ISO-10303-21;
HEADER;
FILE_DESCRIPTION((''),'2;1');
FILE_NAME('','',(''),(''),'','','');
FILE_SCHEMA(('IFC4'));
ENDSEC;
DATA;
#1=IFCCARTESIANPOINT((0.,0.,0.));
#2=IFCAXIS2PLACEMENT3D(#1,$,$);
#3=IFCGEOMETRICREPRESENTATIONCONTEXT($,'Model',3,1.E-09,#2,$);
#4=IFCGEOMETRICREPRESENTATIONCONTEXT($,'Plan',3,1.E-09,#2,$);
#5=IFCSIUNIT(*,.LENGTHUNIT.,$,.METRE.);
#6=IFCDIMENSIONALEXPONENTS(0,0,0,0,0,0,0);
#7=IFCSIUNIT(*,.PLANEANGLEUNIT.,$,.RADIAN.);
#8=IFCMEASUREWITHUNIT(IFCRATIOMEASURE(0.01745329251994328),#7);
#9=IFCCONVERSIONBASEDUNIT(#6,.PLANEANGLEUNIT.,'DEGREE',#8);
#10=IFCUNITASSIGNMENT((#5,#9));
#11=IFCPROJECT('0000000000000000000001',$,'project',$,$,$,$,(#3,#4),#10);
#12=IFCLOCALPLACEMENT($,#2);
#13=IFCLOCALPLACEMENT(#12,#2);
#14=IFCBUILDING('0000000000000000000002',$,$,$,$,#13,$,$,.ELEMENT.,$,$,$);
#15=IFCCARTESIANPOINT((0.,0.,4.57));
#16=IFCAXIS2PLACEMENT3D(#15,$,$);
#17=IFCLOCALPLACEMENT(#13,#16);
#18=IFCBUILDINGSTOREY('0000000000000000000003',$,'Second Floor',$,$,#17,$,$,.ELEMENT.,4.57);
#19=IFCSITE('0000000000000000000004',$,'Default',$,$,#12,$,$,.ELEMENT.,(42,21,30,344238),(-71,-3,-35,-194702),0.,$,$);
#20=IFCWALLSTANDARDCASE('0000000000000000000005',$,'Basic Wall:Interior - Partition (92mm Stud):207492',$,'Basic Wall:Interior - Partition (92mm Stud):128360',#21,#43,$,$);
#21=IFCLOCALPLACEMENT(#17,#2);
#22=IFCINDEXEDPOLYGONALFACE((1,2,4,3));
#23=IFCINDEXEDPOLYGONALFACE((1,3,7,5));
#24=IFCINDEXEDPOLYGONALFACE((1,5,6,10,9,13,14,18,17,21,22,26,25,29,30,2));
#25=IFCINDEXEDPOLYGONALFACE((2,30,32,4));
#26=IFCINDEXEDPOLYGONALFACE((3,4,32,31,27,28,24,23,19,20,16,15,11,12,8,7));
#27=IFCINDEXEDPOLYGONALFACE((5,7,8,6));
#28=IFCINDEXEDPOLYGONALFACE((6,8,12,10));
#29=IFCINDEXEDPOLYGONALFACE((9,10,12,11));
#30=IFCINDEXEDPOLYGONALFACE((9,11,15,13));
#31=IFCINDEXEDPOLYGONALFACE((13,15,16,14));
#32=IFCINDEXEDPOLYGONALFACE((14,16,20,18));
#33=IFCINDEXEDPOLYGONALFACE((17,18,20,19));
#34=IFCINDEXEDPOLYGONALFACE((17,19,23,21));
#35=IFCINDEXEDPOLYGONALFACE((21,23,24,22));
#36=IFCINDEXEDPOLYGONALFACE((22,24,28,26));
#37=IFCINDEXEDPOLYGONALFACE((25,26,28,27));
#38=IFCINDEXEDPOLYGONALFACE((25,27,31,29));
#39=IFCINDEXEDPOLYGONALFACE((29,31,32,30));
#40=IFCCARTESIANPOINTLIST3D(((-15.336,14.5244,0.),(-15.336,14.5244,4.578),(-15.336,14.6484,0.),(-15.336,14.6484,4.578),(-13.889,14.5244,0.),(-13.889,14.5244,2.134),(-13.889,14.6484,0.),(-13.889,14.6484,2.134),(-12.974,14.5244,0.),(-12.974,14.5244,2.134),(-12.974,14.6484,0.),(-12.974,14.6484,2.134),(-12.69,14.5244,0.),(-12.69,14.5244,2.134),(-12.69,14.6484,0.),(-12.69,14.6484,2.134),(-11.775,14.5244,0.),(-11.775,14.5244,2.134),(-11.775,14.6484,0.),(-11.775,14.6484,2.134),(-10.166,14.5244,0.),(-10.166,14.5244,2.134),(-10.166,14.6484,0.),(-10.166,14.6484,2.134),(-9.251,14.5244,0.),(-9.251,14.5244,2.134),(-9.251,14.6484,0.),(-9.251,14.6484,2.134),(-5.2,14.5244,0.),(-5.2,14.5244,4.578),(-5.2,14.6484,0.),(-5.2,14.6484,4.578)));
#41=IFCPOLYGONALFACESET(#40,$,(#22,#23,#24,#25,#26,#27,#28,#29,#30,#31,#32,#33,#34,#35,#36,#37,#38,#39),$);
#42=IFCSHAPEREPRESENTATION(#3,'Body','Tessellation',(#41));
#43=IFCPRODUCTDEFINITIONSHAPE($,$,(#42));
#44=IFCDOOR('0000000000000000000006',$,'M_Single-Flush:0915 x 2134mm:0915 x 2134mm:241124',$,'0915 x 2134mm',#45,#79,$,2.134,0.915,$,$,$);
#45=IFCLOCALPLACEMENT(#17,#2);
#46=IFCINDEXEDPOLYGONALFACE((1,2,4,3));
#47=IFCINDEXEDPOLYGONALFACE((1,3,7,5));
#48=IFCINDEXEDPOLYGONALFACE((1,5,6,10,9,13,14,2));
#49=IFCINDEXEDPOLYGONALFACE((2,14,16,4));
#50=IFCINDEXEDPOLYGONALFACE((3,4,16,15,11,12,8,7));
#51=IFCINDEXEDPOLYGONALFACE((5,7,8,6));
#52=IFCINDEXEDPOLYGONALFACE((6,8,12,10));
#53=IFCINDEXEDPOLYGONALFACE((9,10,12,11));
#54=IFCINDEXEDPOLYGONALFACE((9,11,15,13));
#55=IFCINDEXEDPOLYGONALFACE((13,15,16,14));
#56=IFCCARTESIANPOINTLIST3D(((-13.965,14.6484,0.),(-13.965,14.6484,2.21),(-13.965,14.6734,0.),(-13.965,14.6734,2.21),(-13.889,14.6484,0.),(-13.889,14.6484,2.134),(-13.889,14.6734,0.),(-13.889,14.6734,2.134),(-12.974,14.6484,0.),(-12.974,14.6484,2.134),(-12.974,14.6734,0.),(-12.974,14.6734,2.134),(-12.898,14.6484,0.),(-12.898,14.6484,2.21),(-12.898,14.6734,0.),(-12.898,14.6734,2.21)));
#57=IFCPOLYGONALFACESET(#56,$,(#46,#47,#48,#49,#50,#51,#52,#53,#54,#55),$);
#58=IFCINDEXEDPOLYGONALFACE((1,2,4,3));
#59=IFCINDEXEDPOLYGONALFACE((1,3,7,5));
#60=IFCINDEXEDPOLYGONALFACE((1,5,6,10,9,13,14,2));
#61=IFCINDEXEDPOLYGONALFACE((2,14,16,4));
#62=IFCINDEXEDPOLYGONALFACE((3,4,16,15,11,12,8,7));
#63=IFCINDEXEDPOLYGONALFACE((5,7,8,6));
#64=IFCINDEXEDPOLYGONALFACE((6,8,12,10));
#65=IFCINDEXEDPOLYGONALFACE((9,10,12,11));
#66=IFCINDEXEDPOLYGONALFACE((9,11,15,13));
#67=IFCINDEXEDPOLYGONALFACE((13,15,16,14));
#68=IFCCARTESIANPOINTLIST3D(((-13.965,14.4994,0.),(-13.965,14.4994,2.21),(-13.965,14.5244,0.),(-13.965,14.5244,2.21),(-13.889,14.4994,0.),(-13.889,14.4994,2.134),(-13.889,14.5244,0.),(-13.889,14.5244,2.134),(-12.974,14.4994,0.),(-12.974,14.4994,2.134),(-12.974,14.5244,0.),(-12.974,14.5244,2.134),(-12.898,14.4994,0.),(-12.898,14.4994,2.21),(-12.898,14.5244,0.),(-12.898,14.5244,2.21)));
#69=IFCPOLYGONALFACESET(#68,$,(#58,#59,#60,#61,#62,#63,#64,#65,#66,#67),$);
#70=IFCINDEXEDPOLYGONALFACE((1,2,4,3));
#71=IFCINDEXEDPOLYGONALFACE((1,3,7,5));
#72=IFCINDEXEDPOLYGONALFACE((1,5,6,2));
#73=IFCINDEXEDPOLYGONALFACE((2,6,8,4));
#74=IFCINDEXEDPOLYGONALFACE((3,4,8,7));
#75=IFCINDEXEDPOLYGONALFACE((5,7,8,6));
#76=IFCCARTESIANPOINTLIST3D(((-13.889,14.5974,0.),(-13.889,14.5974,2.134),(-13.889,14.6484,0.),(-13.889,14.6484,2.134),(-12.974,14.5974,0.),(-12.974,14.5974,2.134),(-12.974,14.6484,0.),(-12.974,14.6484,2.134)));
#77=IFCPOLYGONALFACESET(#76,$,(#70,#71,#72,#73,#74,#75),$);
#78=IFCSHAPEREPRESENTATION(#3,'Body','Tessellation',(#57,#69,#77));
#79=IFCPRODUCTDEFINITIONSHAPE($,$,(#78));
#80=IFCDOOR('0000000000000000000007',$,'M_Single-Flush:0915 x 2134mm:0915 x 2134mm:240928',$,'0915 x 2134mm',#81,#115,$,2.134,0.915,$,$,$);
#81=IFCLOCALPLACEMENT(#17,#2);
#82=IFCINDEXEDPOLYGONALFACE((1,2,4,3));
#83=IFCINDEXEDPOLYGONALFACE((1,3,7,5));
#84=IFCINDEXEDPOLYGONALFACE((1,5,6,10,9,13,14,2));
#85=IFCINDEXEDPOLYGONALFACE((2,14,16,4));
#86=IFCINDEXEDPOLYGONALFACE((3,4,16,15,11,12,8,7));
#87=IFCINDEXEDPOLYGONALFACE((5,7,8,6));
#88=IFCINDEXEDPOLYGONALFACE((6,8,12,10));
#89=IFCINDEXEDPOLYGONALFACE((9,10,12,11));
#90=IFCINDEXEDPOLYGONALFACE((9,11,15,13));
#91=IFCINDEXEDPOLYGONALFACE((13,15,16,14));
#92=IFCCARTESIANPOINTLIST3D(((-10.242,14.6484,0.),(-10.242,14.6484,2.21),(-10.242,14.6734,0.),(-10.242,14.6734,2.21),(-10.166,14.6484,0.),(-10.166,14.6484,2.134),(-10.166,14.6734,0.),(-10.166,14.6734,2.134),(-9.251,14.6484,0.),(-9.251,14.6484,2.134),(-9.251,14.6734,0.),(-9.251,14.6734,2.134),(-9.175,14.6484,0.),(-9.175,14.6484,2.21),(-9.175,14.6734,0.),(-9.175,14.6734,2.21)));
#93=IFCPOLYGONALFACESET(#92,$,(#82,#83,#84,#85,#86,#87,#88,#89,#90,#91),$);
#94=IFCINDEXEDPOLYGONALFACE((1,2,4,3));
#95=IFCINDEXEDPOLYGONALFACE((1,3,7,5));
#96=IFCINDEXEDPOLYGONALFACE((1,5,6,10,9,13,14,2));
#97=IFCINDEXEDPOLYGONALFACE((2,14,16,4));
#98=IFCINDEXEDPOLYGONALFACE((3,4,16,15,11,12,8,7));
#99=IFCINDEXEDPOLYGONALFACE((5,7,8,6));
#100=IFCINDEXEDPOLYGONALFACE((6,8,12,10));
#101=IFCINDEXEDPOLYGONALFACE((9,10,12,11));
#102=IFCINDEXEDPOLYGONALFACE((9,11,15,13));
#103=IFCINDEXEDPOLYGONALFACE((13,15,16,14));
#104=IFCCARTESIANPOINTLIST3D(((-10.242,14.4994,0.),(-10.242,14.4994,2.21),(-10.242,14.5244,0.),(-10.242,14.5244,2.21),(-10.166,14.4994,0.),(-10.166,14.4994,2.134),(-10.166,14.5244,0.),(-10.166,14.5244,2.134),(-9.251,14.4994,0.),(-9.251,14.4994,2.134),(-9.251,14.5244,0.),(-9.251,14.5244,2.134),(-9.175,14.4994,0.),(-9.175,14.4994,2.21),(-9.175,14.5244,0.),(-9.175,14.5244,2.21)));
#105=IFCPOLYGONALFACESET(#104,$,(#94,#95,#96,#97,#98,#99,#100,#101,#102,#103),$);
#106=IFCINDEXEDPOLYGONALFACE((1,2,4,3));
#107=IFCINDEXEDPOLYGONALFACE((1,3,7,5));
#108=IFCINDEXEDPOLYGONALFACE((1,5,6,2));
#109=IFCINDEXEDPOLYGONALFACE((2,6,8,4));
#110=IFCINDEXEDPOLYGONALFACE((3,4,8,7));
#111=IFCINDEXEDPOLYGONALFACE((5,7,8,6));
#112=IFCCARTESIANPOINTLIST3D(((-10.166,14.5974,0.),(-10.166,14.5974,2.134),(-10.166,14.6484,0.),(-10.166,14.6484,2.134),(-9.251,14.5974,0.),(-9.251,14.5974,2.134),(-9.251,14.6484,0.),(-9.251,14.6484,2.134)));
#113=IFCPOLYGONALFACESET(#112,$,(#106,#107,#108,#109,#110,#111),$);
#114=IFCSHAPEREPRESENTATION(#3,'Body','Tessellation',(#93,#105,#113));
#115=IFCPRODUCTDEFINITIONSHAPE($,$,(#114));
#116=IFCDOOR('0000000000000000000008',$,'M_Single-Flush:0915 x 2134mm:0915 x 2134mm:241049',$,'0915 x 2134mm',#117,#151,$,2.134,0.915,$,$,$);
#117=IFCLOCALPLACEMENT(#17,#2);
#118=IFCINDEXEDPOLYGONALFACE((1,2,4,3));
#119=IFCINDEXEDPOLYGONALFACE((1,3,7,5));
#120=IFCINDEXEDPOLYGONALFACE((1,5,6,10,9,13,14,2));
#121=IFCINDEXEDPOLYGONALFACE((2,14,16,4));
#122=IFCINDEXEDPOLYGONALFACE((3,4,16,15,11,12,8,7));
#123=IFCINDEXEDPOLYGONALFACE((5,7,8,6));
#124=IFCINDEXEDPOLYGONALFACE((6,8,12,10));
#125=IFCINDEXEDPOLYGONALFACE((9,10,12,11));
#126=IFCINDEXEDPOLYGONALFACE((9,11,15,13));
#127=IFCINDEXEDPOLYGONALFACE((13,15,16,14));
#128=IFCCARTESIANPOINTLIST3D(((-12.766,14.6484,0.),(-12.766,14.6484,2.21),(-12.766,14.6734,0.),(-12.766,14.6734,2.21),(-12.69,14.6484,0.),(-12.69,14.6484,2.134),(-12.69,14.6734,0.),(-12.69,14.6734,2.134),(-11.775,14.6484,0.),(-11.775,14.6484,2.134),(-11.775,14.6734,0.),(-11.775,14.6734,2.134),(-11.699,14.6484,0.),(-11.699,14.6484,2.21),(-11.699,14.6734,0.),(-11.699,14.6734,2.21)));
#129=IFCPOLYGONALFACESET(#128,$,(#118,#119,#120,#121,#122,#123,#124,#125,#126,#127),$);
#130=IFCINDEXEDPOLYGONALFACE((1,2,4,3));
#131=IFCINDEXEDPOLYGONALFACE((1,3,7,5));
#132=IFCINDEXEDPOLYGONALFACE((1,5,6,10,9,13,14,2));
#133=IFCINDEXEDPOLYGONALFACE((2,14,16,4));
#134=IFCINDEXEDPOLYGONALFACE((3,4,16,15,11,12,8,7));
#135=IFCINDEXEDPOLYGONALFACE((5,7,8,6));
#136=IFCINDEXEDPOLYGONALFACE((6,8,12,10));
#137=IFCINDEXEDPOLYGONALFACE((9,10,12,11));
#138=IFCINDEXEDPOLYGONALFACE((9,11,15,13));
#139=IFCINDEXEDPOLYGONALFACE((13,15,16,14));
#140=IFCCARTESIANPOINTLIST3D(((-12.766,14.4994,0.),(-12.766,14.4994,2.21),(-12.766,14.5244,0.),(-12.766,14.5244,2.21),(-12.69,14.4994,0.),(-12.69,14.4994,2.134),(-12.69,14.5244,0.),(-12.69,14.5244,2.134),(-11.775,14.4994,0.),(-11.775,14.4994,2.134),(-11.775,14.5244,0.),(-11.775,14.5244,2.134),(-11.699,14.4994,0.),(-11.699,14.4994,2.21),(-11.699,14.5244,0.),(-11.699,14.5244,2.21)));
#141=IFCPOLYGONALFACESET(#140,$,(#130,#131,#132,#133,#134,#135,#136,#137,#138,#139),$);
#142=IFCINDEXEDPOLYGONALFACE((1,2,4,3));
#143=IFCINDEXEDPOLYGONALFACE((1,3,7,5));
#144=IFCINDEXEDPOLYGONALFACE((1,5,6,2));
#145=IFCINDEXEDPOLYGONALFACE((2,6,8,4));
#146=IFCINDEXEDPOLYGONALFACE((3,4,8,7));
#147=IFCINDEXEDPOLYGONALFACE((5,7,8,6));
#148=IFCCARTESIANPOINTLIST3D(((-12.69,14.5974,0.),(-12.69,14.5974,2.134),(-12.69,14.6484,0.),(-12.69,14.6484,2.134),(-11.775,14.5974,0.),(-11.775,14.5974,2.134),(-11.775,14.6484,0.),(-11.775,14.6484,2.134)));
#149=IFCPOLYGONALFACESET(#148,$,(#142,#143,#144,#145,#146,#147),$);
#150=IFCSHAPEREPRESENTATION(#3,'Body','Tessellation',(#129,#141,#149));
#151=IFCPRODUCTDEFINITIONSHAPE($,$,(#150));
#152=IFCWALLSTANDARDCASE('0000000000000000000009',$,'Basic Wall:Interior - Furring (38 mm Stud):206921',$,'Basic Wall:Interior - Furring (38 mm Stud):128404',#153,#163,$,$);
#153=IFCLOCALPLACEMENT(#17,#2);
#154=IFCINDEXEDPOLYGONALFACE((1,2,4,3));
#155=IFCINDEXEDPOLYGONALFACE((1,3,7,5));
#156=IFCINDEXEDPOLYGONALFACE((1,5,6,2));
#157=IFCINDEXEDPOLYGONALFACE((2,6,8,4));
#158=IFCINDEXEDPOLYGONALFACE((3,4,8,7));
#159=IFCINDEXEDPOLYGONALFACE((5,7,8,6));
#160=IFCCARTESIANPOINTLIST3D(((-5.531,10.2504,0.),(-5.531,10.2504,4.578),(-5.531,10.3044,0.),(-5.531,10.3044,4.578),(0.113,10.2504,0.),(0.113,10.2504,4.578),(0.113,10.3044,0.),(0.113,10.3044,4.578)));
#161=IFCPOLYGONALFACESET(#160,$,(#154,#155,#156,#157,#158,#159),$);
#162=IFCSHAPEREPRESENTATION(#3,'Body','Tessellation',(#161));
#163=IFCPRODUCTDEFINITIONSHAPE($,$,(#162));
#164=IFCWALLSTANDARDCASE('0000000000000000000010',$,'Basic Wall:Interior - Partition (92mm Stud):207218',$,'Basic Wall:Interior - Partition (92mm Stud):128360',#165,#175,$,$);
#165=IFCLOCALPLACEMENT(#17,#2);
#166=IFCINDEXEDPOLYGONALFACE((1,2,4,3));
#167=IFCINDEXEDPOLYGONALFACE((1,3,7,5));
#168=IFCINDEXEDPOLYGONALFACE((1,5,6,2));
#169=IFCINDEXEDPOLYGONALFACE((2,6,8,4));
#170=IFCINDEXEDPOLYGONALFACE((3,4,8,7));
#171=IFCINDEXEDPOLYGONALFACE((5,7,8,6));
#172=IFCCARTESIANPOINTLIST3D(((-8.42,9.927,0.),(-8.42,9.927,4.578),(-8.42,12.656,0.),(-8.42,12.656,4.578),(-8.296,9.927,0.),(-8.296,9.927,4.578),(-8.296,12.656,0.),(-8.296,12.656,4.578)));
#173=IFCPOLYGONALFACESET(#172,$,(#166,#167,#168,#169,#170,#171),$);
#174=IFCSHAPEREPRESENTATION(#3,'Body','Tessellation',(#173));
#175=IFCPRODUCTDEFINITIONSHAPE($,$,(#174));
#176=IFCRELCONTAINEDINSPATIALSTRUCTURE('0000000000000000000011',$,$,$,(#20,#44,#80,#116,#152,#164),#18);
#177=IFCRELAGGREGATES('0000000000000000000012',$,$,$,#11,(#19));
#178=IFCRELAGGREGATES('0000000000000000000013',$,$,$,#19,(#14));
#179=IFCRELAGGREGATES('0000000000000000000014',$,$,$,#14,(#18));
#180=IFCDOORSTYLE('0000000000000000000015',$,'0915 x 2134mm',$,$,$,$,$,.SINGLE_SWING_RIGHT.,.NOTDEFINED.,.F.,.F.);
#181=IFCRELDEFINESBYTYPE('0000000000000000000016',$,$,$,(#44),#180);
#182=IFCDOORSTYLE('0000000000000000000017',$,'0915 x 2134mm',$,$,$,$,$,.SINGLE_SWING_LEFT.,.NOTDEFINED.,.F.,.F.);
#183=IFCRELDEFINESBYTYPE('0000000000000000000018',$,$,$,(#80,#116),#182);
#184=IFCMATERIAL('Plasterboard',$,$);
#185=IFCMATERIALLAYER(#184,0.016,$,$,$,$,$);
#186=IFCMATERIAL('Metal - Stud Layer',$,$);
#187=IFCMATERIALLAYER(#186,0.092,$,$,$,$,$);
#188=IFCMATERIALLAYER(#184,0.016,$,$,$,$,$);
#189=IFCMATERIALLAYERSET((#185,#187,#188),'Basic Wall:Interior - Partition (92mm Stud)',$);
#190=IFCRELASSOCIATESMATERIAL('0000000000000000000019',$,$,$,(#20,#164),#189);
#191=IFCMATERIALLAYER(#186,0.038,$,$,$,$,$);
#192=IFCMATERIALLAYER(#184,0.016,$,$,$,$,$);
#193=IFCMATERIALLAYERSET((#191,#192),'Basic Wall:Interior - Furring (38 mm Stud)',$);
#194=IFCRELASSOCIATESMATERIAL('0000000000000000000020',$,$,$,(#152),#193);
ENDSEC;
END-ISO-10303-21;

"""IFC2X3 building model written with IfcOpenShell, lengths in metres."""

from ifc_helpers import new_model, entity, si_unit, converted_unit, frame, frame_2d, origin, origin_2d_with_axis, place, context, project, spatial, polyline, rectangle, outline, extrude, source, transform, mapped, material, layer, layer_set, layer_usage, type_object, type_shapes, element, fill, save


model = new_model("IFC2X3")

# Units and contexts
model_context = context("Model", 3, precision=1e-09, world=origin())
plan_context = context("Plan", 3, precision=1e-09, world=origin())
ifc_project = project(units=[si_unit("LENGTHUNIT", "METRE"), converted_unit("PLANEANGLEUNIT", "DEGREE", entity("IfcRatioMeasure", 0.01745329251994328), si_unit("PLANEANGLEUNIT", "RADIAN"), dimensions=[0, 0, 0, 0, 0, 0, 0])], contexts=[model_context, plan_context])

# Site, building, storey
site_placement = place(None, origin())
site = spatial("IfcSite", under=ifc_project, at=site_placement, Name="Default", CompositionType="ELEMENT", RefLatitude=(42, 21, 30, 344238), RefLongitude=(-71, -3, -35, -194702), RefElevation=0.0)
building_placement = place(site_placement, origin())
building = spatial("IfcBuilding", under=site, at=building_placement, CompositionType="ELEMENT")
storey_placement = place(building_placement, frame((0.0, 0.0, 4.57)))
storey = spatial("IfcBuildingStorey", under=building, at=storey_placement, Name="Second Floor", CompositionType="ELEMENT", Elevation=4.57)

# Wall, openings, doors
ifc_material_1 = material(Name="Plasterboard")
ifc_layer_1 = layer(ifc_material_1, 0.016)
ifc_material_2 = material(Name="Metal - Stud Layer")
ifc_layer_2 = layer(ifc_material_2, 0.092)
ifc_layer_3 = layer(ifc_material_1, 0.016)
ifc_layer_set_1 = layer_set([ifc_layer_1, ifc_layer_2, ifc_layer_3], Name="Basic Wall:Interior - Partition (92mm Stud)")
ifc_layer_usage_1 = layer_usage(ifc_layer_set_1, "AXIS2", "NEGATIVE", 0.062)
wall_1_placement = place(storey_placement, frame((-5.2, 14.5864, 0.0), z_axis=(0.0, 0.0, 1.0), x_axis=(-1.0, 0.0, 0.0)))
wall_1 = element("IfcWallStandardCase", 1, at=wall_1_placement, inside=storey, material=ifc_layer_usage_1, Name="Basic Wall:Interior - Partition (92mm Stud):207492", ObjectType="Basic Wall:Interior - Partition (92mm Stud):128360", context=model_context, shape_type="SweptSolid", body=[
    extrude(rectangle(XDim=10.136, YDim=0.124, at=frame_2d((5.068, 0.0), x_axis=(-1.0, 0.0))), origin(), (0.0, 0.0, 1.0), 4.578),
])
opening_1_placement = place(wall_1_placement, frame((4.966, 0.062, 0.0)))
opening_1 = element("IfcOpeningElement", 2, at=opening_1_placement, cuts=wall_1, ObjectType="Opening", context=model_context, shape_type="SweptSolid", body=[
    extrude(rectangle(XDim=0.915, YDim=2.134, at=frame_2d((1.067, 0.4575), x_axis=(0.0, -1.0))), frame((0.0, 0.0, 0.0), z_axis=(0.0, -1.0, 0.0), x_axis=(0.0, 0.0, 1.0)), (0.0, 0.0, 1.0), 0.124),
])
opening_2_placement = place(wall_1_placement, frame((8.689, 0.062, 0.0)))
opening_2 = element("IfcOpeningElement", 3, at=opening_2_placement, cuts=wall_1, ObjectType="Opening", context=model_context, shape_type="SweptSolid", body=[
    extrude(rectangle(XDim=0.915, YDim=2.134, at=frame_2d((1.067, 0.4575), x_axis=(0.0, 1.0))), frame((0.0, 0.0, 0.0), z_axis=(0.0, -1.0, 0.0), x_axis=(0.0, 0.0, 1.0)), (0.0, 0.0, 1.0), 0.124),
])
opening_3_placement = place(wall_1_placement, frame((7.49, 0.062, 0.0)))
opening_3 = element("IfcOpeningElement", 4, at=opening_3_placement, cuts=wall_1, ObjectType="Opening", context=model_context, shape_type="SweptSolid", body=[
    extrude(rectangle(XDim=0.915, YDim=2.134, at=frame_2d((1.067, 0.4575), x_axis=(0.0, -1.0))), frame((0.0, 0.0, 0.0), z_axis=(0.0, -1.0, 0.0), x_axis=(0.0, 0.0, 1.0)), (0.0, 0.0, 1.0), 0.124),
])
door_style_1 = type_object("IfcDoorStyle", Name="0915 x 2134mm", ConstructionType="NOTDEFINED", OperationType="SINGLE_SWING_RIGHT", ParameterTakesPrecedence=False, Sizeable=False)
shared_shape_1 = source(origin(), model_context, "Body", "SweptSolid", [
    extrude(outline(polyline([(-0.5335, -1.124), (0.5335, -1.124), (0.5335, 1.086), (0.4575, 1.086), (0.4575, -1.048), (-0.4575, -1.048), (-0.4575, 1.086), (-0.5335, 1.086), (-0.5335, -1.124)])), frame((0.4575, 0.124, 1.086), z_axis=(0.0, 1.0, 0.0), x_axis=(1.0, 0.0, 0.0)), (0.0, 0.0, 1.0), 0.025),
    extrude(outline(polyline([(-1.124, -0.5335), (1.086, -0.5335), (1.086, -0.4575), (-1.048, -0.4575), (-1.048, 0.4575), (1.086, 0.4575), (1.086, 0.5335), (-1.124, 0.5335), (-1.124, -0.5335)])), frame((0.4575, -0.025, 1.086), z_axis=(0.0, 1.0, 0.0), x_axis=(0.0, 0.0, -1.0)), (0.0, 0.0, 1.0), 0.025),
    extrude(rectangle(XDim=0.051, YDim=0.915, at=origin_2d_with_axis()), frame((0.4575, 0.0985, 0.0), z_axis=(0.0, 0.0, 1.0), x_axis=(0.0, 1.0, 0.0)), (0.0, 0.0, 1.0), 2.134),
])
type_shapes(door_style_1, [shared_shape_1])
door_1_placement = place(opening_2_placement, frame((0.0, 0.0, 0.0), z_axis=(0.0, 0.0, 1.0), x_axis=(-1.0, 0.0, 0.0)))
door_1 = element("IfcDoor", 5, at=door_1_placement, inside=storey, type_object=door_style_1, Name="M_Single-Flush:0915 x 2134mm:0915 x 2134mm:241124", ObjectType="0915 x 2134mm", OverallHeight=2.134, OverallWidth=0.915, context=model_context, shape_type="MappedRepresentation", body=[
    mapped(shared_shape_1, transform((0.0, 0.0, 0.0), scale=1.0)),
])
fill(opening_2, door_1)
door_style_2 = type_object("IfcDoorStyle", Name="0915 x 2134mm", ConstructionType="NOTDEFINED", OperationType="SINGLE_SWING_LEFT", ParameterTakesPrecedence=False, Sizeable=False)
shared_shape_2 = source(origin(), model_context, "Body", "SweptSolid", [
    extrude(outline(polyline([(-0.5335, -1.124), (0.5335, -1.124), (0.5335, 1.086), (0.4575, 1.086), (0.4575, -1.048), (-0.4575, -1.048), (-0.4575, 1.086), (-0.5335, 1.086), (-0.5335, -1.124)])), frame((0.4575, 0.149, 1.086), z_axis=(0.0, -1.0, 0.0), x_axis=(-1.0, 0.0, 0.0)), (0.0, 0.0, 1.0), 0.025),
    extrude(outline(polyline([(-1.124, -0.5335), (1.086, -0.5335), (1.086, -0.4575), (-1.048, -0.4575), (-1.048, 0.4575), (1.086, 0.4575), (1.086, 0.5335), (-1.124, 0.5335), (-1.124, -0.5335)])), frame((0.4575, 0.0, 1.086), z_axis=(0.0, -1.0, 0.0), x_axis=(0.0, 0.0, -1.0)), (0.0, 0.0, 1.0), 0.025),
    extrude(rectangle(XDim=0.915, YDim=0.051, at=origin_2d_with_axis()), frame((0.4575, 0.0985, 0.0)), (0.0, 0.0, 1.0), 2.134),
])
type_shapes(door_style_2, [shared_shape_2])
door_2_placement = place(opening_1_placement, frame((0.0, 0.0, 0.0), z_axis=(0.0, 0.0, 1.0), x_axis=(-1.0, 0.0, 0.0)))
door_2 = element("IfcDoor", 6, at=door_2_placement, inside=storey, type_object=door_style_2, Name="M_Single-Flush:0915 x 2134mm:0915 x 2134mm:240928", ObjectType="0915 x 2134mm", OverallHeight=2.134, OverallWidth=0.915, context=model_context, shape_type="MappedRepresentation", body=[
    mapped(shared_shape_2, transform((0.0, 0.0, 0.0), scale=1.0)),
])
fill(opening_1, door_2)
door_3_placement = place(opening_3_placement, frame((0.0, 0.0, 0.0), z_axis=(0.0, 0.0, 1.0), x_axis=(-1.0, 0.0, 0.0)))
door_3 = element("IfcDoor", 7, at=door_3_placement, inside=storey, type_object=door_style_2, Name="M_Single-Flush:0915 x 2134mm:0915 x 2134mm:241049", ObjectType="0915 x 2134mm", OverallHeight=2.134, OverallWidth=0.915, context=model_context, shape_type="MappedRepresentation", body=[
    mapped(shared_shape_2, transform((0.0, 0.0, 0.0), scale=1.0)),
])
fill(opening_3, door_3)

# Walls
ifc_layer_4 = layer(ifc_material_2, 0.038)
ifc_layer_5 = layer(ifc_material_1, 0.016)
ifc_layer_set_2 = layer_set([ifc_layer_4, ifc_layer_5], Name="Basic Wall:Interior - Furring (38 mm Stud)")
ifc_layer_usage_2 = layer_usage(ifc_layer_set_2, "AXIS2", "POSITIVE", -0.027)
wall_2_placement = place(storey_placement, frame((-5.531, 10.2774, 0.0)))
element("IfcWallStandardCase", 8, at=wall_2_placement, inside=storey, material=ifc_layer_usage_2, Name="Basic Wall:Interior - Furring (38 mm Stud):206921", ObjectType="Basic Wall:Interior - Furring (38 mm Stud):128404", context=model_context, shape_type="SweptSolid", body=[
    extrude(rectangle(XDim=5.644, YDim=0.054, at=frame_2d((2.822, 0.0), x_axis=(-1.0, 0.0))), origin(), (0.0, 0.0, 1.0), 4.578),
])
wall_3_placement = place(storey_placement, frame((-8.358, 9.927, 0.0), z_axis=(0.0, 0.0, 1.0), x_axis=(0.0, 1.0, 0.0)))
element("IfcWallStandardCase", 9, at=wall_3_placement, inside=storey, material=ifc_layer_usage_1, Name="Basic Wall:Interior - Partition (92mm Stud):207218", ObjectType="Basic Wall:Interior - Partition (92mm Stud):128360", context=model_context, shape_type="SweptSolid", body=[
    extrude(rectangle(XDim=2.729, YDim=0.124, at=frame_2d((1.3645, 0.0), x_axis=(-1.0, 0.0))), origin(), (0.0, 0.0, 1.0), 4.578),
])

save(model, "model.ifc")
